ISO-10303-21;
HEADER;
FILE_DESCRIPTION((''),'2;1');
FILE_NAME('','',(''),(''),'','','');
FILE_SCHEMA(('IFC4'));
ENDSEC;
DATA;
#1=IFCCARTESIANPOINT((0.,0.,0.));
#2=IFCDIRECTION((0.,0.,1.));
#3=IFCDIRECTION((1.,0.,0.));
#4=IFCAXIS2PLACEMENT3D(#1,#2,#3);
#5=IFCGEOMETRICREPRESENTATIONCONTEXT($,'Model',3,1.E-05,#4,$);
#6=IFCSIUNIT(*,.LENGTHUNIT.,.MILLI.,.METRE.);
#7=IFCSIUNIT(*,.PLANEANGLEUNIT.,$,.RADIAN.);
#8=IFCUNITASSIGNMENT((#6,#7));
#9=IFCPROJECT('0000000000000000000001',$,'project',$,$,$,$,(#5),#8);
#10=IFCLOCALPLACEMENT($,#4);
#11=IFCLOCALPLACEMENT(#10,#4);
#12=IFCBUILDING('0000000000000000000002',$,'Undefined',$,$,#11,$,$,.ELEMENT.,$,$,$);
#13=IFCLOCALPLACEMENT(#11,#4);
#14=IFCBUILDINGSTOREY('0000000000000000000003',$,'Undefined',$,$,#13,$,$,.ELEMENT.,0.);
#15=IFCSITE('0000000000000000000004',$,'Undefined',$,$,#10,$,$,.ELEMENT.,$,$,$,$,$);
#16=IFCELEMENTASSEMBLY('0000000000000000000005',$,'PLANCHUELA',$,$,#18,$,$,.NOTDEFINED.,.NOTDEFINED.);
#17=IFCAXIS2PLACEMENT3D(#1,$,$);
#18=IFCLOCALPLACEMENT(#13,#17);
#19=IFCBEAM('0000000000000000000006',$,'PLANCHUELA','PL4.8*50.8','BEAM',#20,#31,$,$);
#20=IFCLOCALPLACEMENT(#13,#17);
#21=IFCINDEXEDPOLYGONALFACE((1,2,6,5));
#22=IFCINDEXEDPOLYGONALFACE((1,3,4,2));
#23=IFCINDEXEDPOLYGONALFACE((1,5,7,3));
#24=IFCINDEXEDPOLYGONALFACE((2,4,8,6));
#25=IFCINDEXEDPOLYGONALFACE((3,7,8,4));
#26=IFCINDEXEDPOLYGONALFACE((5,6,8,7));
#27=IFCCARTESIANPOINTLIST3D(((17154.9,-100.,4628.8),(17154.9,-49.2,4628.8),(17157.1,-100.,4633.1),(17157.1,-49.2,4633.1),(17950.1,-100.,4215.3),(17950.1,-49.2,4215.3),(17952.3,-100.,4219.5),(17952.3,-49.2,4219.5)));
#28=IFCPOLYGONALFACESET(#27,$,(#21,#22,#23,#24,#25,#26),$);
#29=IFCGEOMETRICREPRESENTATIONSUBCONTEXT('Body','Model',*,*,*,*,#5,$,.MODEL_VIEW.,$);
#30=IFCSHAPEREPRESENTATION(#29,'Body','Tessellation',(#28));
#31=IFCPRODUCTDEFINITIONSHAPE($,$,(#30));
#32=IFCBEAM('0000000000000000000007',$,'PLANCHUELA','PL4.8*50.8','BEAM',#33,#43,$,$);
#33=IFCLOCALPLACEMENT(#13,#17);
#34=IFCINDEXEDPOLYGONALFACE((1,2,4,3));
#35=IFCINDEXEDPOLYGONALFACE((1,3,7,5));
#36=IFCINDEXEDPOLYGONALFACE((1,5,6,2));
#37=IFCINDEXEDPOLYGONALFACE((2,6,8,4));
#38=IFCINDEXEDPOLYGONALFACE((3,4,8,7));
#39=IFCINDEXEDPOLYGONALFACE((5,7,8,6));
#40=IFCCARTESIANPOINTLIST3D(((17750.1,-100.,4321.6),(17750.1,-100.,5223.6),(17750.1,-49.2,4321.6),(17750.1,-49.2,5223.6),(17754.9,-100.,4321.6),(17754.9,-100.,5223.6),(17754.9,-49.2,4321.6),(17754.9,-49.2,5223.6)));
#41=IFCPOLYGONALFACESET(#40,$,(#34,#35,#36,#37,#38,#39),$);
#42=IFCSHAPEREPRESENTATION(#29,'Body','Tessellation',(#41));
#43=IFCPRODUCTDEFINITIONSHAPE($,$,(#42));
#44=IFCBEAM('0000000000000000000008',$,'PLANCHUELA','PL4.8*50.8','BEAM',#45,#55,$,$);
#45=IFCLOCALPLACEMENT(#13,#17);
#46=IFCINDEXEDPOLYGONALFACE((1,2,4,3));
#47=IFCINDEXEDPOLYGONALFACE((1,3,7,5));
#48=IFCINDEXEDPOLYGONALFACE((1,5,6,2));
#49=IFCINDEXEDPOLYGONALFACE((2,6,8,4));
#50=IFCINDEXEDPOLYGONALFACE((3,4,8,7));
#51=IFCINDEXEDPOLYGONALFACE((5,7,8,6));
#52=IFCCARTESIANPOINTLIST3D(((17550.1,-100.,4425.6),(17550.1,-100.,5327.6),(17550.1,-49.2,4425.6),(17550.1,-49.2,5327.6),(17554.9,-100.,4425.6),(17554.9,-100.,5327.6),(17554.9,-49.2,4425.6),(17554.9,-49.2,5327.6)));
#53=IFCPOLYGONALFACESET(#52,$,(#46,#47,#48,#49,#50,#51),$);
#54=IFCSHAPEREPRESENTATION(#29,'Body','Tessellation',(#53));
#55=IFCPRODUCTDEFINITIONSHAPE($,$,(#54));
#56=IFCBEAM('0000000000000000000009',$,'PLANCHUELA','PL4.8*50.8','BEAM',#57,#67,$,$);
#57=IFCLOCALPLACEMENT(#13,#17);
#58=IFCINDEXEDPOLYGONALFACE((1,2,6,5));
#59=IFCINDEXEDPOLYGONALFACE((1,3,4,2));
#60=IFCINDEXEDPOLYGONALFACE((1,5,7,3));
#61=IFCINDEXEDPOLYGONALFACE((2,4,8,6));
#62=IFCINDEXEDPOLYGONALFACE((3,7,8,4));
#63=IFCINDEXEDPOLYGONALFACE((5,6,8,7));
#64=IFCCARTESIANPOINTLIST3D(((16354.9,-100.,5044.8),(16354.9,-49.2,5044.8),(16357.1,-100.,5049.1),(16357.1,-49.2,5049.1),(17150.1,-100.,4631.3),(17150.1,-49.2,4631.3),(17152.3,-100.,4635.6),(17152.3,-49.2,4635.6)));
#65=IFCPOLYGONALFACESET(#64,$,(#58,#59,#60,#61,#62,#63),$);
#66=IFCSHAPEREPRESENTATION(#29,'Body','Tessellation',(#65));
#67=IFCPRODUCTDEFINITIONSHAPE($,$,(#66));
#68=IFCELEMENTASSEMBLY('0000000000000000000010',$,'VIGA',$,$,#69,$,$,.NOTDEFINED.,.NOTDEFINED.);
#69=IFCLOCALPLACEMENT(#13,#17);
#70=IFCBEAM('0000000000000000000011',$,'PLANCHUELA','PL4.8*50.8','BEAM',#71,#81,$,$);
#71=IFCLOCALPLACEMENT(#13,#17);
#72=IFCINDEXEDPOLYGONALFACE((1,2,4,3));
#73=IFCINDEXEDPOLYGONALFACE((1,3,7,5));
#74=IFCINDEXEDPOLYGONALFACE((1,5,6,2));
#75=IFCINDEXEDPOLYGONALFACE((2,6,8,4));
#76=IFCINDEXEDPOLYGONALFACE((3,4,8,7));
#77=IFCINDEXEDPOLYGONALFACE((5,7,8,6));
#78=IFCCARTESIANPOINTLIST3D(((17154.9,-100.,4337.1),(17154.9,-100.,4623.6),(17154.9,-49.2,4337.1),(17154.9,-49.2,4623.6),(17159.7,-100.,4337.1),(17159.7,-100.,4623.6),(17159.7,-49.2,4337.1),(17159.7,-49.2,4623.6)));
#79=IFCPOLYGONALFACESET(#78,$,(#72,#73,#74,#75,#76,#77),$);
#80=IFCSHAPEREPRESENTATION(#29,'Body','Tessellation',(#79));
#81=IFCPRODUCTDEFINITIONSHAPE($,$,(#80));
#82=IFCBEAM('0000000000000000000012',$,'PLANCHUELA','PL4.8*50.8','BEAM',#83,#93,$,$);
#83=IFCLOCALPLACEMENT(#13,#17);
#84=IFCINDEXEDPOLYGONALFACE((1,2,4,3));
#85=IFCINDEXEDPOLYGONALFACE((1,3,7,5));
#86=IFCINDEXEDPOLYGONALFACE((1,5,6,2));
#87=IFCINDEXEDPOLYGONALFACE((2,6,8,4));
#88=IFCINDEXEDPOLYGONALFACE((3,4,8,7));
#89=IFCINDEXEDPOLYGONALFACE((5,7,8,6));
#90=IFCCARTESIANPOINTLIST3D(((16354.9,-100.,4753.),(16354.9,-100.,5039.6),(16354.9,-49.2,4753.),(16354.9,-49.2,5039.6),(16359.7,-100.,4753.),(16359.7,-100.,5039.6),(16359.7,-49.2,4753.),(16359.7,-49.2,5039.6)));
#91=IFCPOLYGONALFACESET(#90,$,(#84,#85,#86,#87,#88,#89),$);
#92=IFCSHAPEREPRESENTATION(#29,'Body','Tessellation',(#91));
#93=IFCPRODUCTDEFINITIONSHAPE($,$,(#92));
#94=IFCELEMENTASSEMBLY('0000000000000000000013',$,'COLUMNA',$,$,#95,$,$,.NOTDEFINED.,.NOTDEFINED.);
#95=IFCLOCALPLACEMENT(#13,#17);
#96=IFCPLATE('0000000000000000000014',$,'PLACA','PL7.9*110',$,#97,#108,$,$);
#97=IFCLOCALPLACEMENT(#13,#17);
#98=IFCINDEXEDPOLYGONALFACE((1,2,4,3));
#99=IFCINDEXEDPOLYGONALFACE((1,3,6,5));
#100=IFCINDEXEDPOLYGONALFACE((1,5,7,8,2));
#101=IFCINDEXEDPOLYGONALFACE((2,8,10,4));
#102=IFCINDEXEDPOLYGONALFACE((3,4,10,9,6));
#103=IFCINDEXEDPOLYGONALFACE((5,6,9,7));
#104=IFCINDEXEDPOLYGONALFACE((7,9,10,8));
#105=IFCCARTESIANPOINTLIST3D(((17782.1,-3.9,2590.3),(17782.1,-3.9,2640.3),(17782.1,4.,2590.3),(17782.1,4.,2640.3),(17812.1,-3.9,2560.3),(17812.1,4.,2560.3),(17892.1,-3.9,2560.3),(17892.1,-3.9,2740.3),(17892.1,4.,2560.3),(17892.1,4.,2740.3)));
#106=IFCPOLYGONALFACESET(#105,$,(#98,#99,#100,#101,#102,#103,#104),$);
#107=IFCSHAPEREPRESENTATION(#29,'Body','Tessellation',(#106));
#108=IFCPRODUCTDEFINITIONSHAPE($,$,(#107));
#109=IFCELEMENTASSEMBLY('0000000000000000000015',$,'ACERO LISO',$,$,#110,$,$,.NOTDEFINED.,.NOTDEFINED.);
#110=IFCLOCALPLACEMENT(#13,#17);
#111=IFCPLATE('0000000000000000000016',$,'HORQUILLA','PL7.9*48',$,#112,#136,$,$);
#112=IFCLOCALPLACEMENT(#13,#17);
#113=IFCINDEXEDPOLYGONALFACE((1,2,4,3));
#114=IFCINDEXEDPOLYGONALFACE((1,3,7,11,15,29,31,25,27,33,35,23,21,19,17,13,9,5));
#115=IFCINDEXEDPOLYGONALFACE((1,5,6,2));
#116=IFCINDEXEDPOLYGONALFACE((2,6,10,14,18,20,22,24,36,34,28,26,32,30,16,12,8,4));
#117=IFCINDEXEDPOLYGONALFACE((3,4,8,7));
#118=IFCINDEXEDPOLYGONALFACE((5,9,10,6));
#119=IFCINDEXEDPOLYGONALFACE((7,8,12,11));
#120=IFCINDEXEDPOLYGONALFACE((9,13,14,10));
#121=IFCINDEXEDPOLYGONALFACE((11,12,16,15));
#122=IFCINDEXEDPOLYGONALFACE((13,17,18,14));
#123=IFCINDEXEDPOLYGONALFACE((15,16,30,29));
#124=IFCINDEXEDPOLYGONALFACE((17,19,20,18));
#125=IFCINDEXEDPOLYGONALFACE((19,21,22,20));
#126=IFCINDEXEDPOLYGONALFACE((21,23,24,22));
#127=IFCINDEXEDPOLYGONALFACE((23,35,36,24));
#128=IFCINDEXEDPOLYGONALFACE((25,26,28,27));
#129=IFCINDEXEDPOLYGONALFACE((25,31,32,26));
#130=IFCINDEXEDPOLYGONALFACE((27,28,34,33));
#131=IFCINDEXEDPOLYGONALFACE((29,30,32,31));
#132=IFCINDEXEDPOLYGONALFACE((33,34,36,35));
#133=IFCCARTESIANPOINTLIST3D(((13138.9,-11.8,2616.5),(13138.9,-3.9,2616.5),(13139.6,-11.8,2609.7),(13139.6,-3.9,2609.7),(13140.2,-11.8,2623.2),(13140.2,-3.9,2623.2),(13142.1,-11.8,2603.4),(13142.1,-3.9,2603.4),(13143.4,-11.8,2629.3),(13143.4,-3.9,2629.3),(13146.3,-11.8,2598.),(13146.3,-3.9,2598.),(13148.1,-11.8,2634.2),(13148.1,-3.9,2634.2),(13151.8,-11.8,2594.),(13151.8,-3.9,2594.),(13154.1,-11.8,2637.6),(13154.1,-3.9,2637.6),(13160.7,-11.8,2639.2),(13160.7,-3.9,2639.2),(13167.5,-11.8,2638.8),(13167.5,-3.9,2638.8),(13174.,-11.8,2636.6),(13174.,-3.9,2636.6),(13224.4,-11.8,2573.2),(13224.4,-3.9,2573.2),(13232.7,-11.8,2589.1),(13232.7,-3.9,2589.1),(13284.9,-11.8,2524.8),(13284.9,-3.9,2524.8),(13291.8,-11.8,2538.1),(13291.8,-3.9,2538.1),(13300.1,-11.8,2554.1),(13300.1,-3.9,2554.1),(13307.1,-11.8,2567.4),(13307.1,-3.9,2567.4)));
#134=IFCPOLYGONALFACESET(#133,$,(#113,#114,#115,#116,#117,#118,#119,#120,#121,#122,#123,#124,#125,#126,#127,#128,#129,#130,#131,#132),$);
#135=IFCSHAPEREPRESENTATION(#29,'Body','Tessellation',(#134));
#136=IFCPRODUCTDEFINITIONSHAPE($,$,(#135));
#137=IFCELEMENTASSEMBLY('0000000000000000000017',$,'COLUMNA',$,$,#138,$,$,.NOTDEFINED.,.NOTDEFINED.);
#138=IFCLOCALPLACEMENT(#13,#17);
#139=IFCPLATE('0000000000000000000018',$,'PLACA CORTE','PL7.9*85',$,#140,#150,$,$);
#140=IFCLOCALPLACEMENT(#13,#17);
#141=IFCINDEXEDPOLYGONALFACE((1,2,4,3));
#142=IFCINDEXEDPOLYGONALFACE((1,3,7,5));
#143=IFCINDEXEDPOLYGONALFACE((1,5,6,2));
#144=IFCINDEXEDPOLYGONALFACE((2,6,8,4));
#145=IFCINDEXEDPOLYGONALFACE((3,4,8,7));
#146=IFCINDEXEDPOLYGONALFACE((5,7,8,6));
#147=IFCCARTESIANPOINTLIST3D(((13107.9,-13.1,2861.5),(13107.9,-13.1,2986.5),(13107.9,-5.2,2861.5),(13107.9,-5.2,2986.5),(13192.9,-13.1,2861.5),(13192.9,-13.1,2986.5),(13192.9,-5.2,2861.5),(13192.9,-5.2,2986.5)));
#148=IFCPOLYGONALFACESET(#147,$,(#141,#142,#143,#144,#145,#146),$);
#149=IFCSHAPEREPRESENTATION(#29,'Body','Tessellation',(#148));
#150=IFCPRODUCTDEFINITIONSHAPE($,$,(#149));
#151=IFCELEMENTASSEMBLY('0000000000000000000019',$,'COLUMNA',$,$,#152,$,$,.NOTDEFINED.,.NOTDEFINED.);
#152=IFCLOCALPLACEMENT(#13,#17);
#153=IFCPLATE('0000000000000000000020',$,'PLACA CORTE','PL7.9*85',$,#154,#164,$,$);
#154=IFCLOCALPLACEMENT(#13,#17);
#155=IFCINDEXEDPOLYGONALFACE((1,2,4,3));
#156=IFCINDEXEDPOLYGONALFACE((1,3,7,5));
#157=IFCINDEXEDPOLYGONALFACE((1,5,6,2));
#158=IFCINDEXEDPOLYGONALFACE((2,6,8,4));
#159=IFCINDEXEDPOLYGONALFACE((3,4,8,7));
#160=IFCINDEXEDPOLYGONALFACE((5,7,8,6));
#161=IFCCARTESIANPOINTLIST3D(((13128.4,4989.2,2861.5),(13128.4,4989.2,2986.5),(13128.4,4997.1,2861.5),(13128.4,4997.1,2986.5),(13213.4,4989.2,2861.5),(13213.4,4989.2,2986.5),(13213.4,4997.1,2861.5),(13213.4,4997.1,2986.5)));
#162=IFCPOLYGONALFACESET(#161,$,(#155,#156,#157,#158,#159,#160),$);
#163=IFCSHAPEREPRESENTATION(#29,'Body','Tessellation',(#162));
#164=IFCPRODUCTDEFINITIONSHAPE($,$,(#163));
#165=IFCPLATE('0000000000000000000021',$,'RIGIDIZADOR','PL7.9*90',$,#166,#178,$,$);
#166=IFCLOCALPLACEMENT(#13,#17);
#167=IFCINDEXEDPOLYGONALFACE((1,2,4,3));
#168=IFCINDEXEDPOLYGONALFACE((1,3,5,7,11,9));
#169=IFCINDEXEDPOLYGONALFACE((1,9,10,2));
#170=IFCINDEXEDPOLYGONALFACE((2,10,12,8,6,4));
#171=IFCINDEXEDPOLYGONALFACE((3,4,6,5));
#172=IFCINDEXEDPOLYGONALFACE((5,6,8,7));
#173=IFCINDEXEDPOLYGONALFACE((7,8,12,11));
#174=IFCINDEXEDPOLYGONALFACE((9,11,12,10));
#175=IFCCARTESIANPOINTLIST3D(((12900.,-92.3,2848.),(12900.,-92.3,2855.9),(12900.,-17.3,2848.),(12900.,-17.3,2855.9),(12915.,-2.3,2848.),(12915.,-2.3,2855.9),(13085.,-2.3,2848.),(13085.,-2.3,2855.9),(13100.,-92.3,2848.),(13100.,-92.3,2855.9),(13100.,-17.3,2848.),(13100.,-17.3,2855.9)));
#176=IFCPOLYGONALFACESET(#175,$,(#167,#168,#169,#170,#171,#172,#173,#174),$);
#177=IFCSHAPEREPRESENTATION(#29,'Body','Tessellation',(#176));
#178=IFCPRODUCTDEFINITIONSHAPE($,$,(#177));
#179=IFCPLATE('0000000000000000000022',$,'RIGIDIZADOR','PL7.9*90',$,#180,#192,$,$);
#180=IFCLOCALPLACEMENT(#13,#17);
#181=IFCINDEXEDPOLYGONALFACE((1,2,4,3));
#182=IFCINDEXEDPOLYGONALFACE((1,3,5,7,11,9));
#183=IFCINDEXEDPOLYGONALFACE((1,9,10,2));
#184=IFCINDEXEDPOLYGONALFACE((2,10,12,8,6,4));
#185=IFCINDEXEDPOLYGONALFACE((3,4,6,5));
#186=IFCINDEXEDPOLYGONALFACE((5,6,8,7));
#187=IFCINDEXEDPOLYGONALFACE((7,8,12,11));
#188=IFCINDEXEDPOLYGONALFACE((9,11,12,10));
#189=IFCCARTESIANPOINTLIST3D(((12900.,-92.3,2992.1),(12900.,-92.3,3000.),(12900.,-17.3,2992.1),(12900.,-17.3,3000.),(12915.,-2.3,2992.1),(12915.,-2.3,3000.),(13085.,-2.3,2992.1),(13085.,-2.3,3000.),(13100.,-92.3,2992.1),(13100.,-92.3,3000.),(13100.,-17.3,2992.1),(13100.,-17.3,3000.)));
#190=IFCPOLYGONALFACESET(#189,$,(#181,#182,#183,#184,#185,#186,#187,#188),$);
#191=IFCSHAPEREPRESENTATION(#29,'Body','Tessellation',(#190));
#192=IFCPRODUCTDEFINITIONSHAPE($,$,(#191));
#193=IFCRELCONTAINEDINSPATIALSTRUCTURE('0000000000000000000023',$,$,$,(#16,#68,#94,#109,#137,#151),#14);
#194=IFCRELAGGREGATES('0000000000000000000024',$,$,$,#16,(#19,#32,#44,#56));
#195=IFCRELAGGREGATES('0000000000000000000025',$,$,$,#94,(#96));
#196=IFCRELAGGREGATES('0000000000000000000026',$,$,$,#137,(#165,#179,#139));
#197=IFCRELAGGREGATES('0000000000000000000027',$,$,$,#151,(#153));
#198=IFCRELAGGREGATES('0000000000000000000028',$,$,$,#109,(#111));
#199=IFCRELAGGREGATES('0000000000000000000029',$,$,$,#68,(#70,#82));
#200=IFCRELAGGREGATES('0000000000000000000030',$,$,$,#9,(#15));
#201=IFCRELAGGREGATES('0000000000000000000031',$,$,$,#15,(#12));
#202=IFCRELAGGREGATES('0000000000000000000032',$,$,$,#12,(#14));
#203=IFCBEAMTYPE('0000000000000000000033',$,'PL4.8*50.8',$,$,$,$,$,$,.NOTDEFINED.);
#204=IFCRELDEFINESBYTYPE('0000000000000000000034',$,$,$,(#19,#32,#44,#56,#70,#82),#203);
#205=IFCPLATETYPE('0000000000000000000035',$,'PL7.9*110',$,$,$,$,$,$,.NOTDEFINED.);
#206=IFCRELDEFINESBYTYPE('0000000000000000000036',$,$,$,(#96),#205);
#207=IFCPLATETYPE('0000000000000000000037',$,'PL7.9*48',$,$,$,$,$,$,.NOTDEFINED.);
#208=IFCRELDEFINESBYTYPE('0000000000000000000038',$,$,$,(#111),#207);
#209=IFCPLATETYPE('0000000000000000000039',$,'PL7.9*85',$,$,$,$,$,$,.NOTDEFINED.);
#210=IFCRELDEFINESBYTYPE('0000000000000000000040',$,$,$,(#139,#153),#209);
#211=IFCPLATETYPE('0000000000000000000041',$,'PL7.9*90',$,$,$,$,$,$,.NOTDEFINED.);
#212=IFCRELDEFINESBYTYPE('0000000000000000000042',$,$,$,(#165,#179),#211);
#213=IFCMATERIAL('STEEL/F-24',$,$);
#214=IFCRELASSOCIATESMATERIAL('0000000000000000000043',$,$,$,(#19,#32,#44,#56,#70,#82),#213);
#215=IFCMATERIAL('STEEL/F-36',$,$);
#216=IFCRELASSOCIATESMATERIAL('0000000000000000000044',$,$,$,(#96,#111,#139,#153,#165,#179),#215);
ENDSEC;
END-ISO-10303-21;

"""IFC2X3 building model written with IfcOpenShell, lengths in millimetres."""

from ifc_helpers import new_model, si_unit, frame, frame_2d, origin_with_axes, origin_2d_with_axis, place, context, subcontext, project, spatial, polyline, circle_curve, parameter, trimmed, segment, composite_curve, rectangle, outline, extrude, boolean, material, type_object, element, aggregate, save


model = new_model("IFC2X3")

# Units and contexts
model_context = context("Model", 3, precision=1e-05, world=origin_with_axes())
body_context = subcontext(model_context, "Body", "Model", "MODEL_VIEW")
ifc_project = project(units=[si_unit("LENGTHUNIT", "METRE", prefix="MILLI"), si_unit("PLANEANGLEUNIT", "RADIAN")], contexts=[model_context])

# Site, building, storey
site_placement = place(None, origin_with_axes())
site = spatial("IfcSite", under=ifc_project, at=site_placement, Name="Undefined", CompositionType="ELEMENT")
building_placement = place(site_placement, origin_with_axes())
building = spatial("IfcBuilding", under=site, at=building_placement, Name="Undefined", CompositionType="ELEMENT")
storey_placement = place(building_placement, origin_with_axes())
storey = spatial("IfcBuildingStorey", under=building, at=storey_placement, Name="Undefined", CompositionType="ELEMENT", Elevation=0.0)

# Element assemblies, beams
assembly_1_placement = place(storey_placement, origin_with_axes())
assembly_1 = element("IfcElementAssembly", 1, at=assembly_1_placement, inside=storey, Name="PLANCHUELA", AssemblyPlace="NOTDEFINED", PredefinedType="NOTDEFINED")
ifc_material_1 = material(Name="STEEL/F-24")
beam_type = type_object("IfcBeamType", Name="PL4.8*50.8", PredefinedType="NOTDEFINED")
beam_1_placement = place(assembly_1_placement, frame((17156.0, -74.6, 4630.9), z_axis=(0.0, 1.0, 0.0), x_axis=(0.887217, 0.0, -0.461353)))
beam_1 = element("IfcBeam", 2, at=beam_1_placement, type_object=beam_type, material=ifc_material_1, Name="PLANCHUELA", Description="PL4.8*50.8", ObjectType="BEAM", context=body_context, shape_type="SweptSolid", body=[
    extrude(rectangle(XDim=4.8, YDim=50.8, at=origin_2d_with_axis()), frame((896.3, 0.0, 0.0), z_axis=(-1.0, 0.0, 0.0), x_axis=(0.0, -1.0, 0.0)), (0.0, 0.0, 1.0), 896.3),
])
beam_2_placement = place(assembly_1_placement, frame((17752.5, -74.6, 5223.6), z_axis=(0.0, 1.0, 0.0), x_axis=(0.0, 0.0, -1.0)))
beam_2 = element("IfcBeam", 3, at=beam_2_placement, type_object=beam_type, material=ifc_material_1, Name="PLANCHUELA", Description="PL4.8*50.8", ObjectType="BEAM", context=body_context, shape_type="SweptSolid", body=[
    extrude(rectangle(XDim=4.8, YDim=50.8, at=origin_2d_with_axis()), frame((902.0, 0.0, 0.0), z_axis=(-1.0, 0.0, 0.0), x_axis=(0.0, -1.0, 0.0)), (0.0, 0.0, 1.0), 902.0),
])
beam_3_placement = place(assembly_1_placement, frame((17552.5, -74.6, 5327.6), z_axis=(0.0, 1.0, 0.0), x_axis=(0.0, 0.0, -1.0)))
beam_3 = element("IfcBeam", 4, at=beam_3_placement, type_object=beam_type, material=ifc_material_1, Name="PLANCHUELA", Description="PL4.8*50.8", ObjectType="BEAM", context=body_context, shape_type="SweptSolid", body=[
    extrude(rectangle(XDim=4.8, YDim=50.8, at=origin_2d_with_axis()), frame((902.0, 0.0, 0.0), z_axis=(-1.0, 0.0, 0.0), x_axis=(0.0, -1.0, 0.0)), (0.0, 0.0, 1.0), 902.0),
])
beam_4_placement = place(assembly_1_placement, frame((16356.0, -74.6, 5047.0), z_axis=(0.0, 1.0, 0.0), x_axis=(0.887217, 0.0, -0.461353)))
beam_4 = element("IfcBeam", 5, at=beam_4_placement, type_object=beam_type, material=ifc_material_1, Name="PLANCHUELA", Description="PL4.8*50.8", ObjectType="BEAM", context=body_context, shape_type="SweptSolid", body=[
    extrude(rectangle(XDim=4.8, YDim=50.8, at=origin_2d_with_axis()), frame((896.3, 0.0, 0.0), z_axis=(-1.0, 0.0, 0.0), x_axis=(0.0, -1.0, 0.0)), (0.0, 0.0, 1.0), 896.3),
])
aggregate(assembly_1, [beam_1, beam_2, beam_3, beam_4])
assembly_2_placement = place(storey_placement, origin_with_axes())
assembly_2 = element("IfcElementAssembly", 6, at=assembly_2_placement, inside=storey, Name="VIGA", AssemblyPlace="NOTDEFINED", PredefinedType="NOTDEFINED")
beam_5_placement = place(assembly_2_placement, frame((17157.3, -74.6, 4623.6), z_axis=(0.0, -1.0, 0.0), x_axis=(0.0, 0.0, -1.0)))
beam_5 = element("IfcBeam", 7, at=beam_5_placement, type_object=beam_type, material=ifc_material_1, Name="PLANCHUELA", Description="PL4.8*50.8", ObjectType="BEAM", context=body_context, shape_type="SweptSolid", body=[
    extrude(rectangle(XDim=4.8, YDim=50.8, at=origin_2d_with_axis()), frame((286.5, 0.0, 0.0), z_axis=(-1.0, 0.0, 0.0), x_axis=(0.0, -1.0, 0.0)), (0.0, 0.0, 1.0), 286.6),
])
beam_6_placement = place(assembly_2_placement, frame((16357.3, -74.6, 5039.6), z_axis=(0.0, -1.0, 0.0), x_axis=(0.0, 0.0, -1.0)))
beam_6 = element("IfcBeam", 8, at=beam_6_placement, type_object=beam_type, material=ifc_material_1, Name="PLANCHUELA", Description="PL4.8*50.8", ObjectType="BEAM", context=body_context, shape_type="SweptSolid", body=[
    extrude(rectangle(XDim=4.8, YDim=50.8, at=origin_2d_with_axis()), frame((286.5, 0.0, 0.0), z_axis=(-1.0, 0.0, 0.0), x_axis=(0.0, -1.0, 0.0)), (0.0, 0.0, 1.0), 286.6),
])

# Element assemblies, plates
assembly_3_placement = place(storey_placement, origin_with_axes())
assembly_3 = element("IfcElementAssembly", 9, at=assembly_3_placement, inside=storey, Name="COLUMNA", AssemblyPlace="NOTDEFINED", PredefinedType="NOTDEFINED")
ifc_material_2 = material(Name="STEEL/F-36")
plate_type_1 = type_object("IfcPlateType", Name="PL7.9*110", PredefinedType="NOTDEFINED")
plate_1_placement = place(assembly_3_placement, frame((17812.1, 0.0, 2560.3), z_axis=(0.0, -1.0, 0.0), x_axis=(1.0, 0.0, 0.0)))
plate_1 = element("IfcPlate", 10, at=plate_1_placement, type_object=plate_type_1, material=ifc_material_2, Name="PLACA", Description="PL7.9*110", context=body_context, shape_type="SweptSolid", body=[
    extrude(outline(polyline([(0.0, 0.0), (80.0, 0.0), (80.0, 180.0), (-30.0, 80.0), (-30.0, 30.0), (0.0, 0.0)])), frame((0.0, 0.0, -4.0), z_axis=(0.0, 0.0, 1.0), x_axis=(1.0, 0.0, 0.0)), (0.0, 0.0, 1.0), 7.9),
])
aggregate(assembly_3, [plate_1])
assembly_4_placement = place(storey_placement, origin_with_axes())
assembly_4 = element("IfcElementAssembly", 11, at=assembly_4_placement, inside=storey, Name="ACERO LISO", AssemblyPlace="NOTDEFINED", PredefinedType="NOTDEFINED")
plate_type_2 = type_object("IfcPlateType", Name="PL7.9*48", PredefinedType="NOTDEFINED")
plate_2_placement = place(assembly_4_placement, frame((13130.5, -7.9, 2605.1), z_axis=(0.0, 1.0, 0.0), x_axis=(0.461353, 0.0, 0.887217)))
plate_2 = element("IfcPlate", 12, at=plate_2_placement, type_object=plate_type_2, material=ifc_material_2, Name="HORQUILLA", Description="PL7.9*48", context=body_context, shape_type="CSG", body=[
    boolean("DIFFERENCE", extrude(outline(composite_curve([segment(trimmed(circle_curve(frame_2d((24.0, 24.0), x_axis=(-1.0, 0.0)), 24.0), [parameter(0.0)], [parameter(1.570796)], True, "PARAMETER"), True, "CONTINUOUS"), segment(polyline([(24.0, 0.0), (24.0, 0.0)]), True, "CONTINUOUS"), segment(trimmed(circle_curve(frame_2d((24.0, 24.0), x_axis=(0.0, -1.0)), 24.0), [parameter(0.0)], [parameter(1.570796)], True, "PARAMETER"), True, "CONTINUOUS"), segment(polyline([(48.0, 24.0), (48.0, 174.0), (0.0, 174.0), (0.0, 24.0)]), True, "CONTINUOUS")], self_intersect=True)), frame((0.0, 0.0, -4.0), z_axis=(0.0, 0.0, 1.0), x_axis=(1.0, 0.0, 0.0)), (0.0, 0.0, 1.0), 7.9), extrude(rectangle(XDim=18.0, YDim=18.0, at=origin_2d_with_axis()), frame((24.0, 274.0, 0.0), z_axis=(0.0, -1.0, 0.0), x_axis=(0.0, 0.0, -1.0)), (0.0, 0.0, 1.0), 176.0)),
])
assembly_5_placement = place(storey_placement, origin_with_axes())
assembly_5 = element("IfcElementAssembly", 13, at=assembly_5_placement, inside=storey, Name="COLUMNA", AssemblyPlace="NOTDEFINED", PredefinedType="NOTDEFINED")
plate_type_3 = type_object("IfcPlateType", Name="PL7.9*85", PredefinedType="NOTDEFINED")
plate_3_placement = place(assembly_5_placement, frame((13107.9, -9.1, 2861.5), z_axis=(0.000002, -1.0, 0.0), x_axis=(1.0, 0.000003, 0.0)))
plate_3 = element("IfcPlate", 14, at=plate_3_placement, type_object=plate_type_3, material=ifc_material_2, Name="PLACA CORTE", Description="PL7.9*85", context=body_context, shape_type="SweptSolid", body=[
    extrude(outline(polyline([(0.0, 0.0), (85.0, 0.0), (85.0, 125.0), (0.0, 125.0), (0.0, 0.0)])), frame((0.0, 0.0, -4.0), z_axis=(0.0, 0.0, 1.0), x_axis=(1.0, 0.0, 0.0)), (0.0, 0.0, 1.0), 7.9),
])
assembly_6_placement = place(storey_placement, origin_with_axes())
assembly_6 = element("IfcElementAssembly", 15, at=assembly_6_placement, inside=storey, Name="COLUMNA", AssemblyPlace="NOTDEFINED", PredefinedType="NOTDEFINED")
plate_4_placement = place(assembly_6_placement, frame((13128.4, 4993.1, 2861.5), z_axis=(0.000002, -1.0, 0.0), x_axis=(1.0, 0.000003, 0.0)))
plate_4 = element("IfcPlate", 16, at=plate_4_placement, type_object=plate_type_3, material=ifc_material_2, Name="PLACA CORTE", Description="PL7.9*85", context=body_context, shape_type="SweptSolid", body=[
    extrude(outline(polyline([(0.0, 0.0), (85.0, 0.0), (85.0, 125.0), (0.0, 125.0), (0.0, 0.0)])), frame((0.0, 0.0, -4.0), z_axis=(0.0, 0.0, 1.0), x_axis=(1.0, 0.0, 0.0)), (0.0, 0.0, 1.0), 7.9),
])

# Plates
plate_type_4 = type_object("IfcPlateType", Name="PL7.9*90", PredefinedType="NOTDEFINED")
plate_5_placement = place(assembly_5_placement, frame((13100.0, -2.3, 2851.9), z_axis=(0.0, 0.0, -1.0), x_axis=(0.0, -1.0, 0.0)))
plate_5 = element("IfcPlate", 17, at=plate_5_placement, type_object=plate_type_4, material=ifc_material_2, Name="RIGIDIZADOR", Description="PL7.9*90", context=body_context, shape_type="SweptSolid", body=[
    extrude(outline(polyline([(0.0, 15.0), (15.0, 0.0), (90.0, 0.0), (90.0, 200.0), (15.0, 200.0), (0.0, 185.0), (0.0, 15.0)])), frame((0.0, 0.0, -4.0), z_axis=(0.0, 0.0, 1.0), x_axis=(1.0, 0.0, 0.0)), (0.0, 0.0, 1.0), 7.9),
])
plate_6_placement = place(assembly_5_placement, frame((13100.0, -2.3, 2996.1), z_axis=(0.0, 0.0, -1.0), x_axis=(0.0, -1.0, 0.0)))
plate_6 = element("IfcPlate", 18, at=plate_6_placement, type_object=plate_type_4, material=ifc_material_2, Name="RIGIDIZADOR", Description="PL7.9*90", context=body_context, shape_type="SweptSolid", body=[
    extrude(outline(polyline([(0.0, 15.0), (15.0, 0.0), (90.0, 0.0), (90.0, 200.0), (15.0, 200.0), (0.0, 185.0), (0.0, 15.0)])), frame((0.0, 0.0, -4.0), z_axis=(0.0, 0.0, 1.0), x_axis=(1.0, 0.0, 0.0)), (0.0, 0.0, 1.0), 7.9),
])
aggregate(assembly_5, [plate_5, plate_6, plate_3])
aggregate(assembly_6, [plate_4])

aggregate(assembly_4, [plate_2])
aggregate(assembly_2, [beam_5, beam_6])

save(model, "model.ifc")
